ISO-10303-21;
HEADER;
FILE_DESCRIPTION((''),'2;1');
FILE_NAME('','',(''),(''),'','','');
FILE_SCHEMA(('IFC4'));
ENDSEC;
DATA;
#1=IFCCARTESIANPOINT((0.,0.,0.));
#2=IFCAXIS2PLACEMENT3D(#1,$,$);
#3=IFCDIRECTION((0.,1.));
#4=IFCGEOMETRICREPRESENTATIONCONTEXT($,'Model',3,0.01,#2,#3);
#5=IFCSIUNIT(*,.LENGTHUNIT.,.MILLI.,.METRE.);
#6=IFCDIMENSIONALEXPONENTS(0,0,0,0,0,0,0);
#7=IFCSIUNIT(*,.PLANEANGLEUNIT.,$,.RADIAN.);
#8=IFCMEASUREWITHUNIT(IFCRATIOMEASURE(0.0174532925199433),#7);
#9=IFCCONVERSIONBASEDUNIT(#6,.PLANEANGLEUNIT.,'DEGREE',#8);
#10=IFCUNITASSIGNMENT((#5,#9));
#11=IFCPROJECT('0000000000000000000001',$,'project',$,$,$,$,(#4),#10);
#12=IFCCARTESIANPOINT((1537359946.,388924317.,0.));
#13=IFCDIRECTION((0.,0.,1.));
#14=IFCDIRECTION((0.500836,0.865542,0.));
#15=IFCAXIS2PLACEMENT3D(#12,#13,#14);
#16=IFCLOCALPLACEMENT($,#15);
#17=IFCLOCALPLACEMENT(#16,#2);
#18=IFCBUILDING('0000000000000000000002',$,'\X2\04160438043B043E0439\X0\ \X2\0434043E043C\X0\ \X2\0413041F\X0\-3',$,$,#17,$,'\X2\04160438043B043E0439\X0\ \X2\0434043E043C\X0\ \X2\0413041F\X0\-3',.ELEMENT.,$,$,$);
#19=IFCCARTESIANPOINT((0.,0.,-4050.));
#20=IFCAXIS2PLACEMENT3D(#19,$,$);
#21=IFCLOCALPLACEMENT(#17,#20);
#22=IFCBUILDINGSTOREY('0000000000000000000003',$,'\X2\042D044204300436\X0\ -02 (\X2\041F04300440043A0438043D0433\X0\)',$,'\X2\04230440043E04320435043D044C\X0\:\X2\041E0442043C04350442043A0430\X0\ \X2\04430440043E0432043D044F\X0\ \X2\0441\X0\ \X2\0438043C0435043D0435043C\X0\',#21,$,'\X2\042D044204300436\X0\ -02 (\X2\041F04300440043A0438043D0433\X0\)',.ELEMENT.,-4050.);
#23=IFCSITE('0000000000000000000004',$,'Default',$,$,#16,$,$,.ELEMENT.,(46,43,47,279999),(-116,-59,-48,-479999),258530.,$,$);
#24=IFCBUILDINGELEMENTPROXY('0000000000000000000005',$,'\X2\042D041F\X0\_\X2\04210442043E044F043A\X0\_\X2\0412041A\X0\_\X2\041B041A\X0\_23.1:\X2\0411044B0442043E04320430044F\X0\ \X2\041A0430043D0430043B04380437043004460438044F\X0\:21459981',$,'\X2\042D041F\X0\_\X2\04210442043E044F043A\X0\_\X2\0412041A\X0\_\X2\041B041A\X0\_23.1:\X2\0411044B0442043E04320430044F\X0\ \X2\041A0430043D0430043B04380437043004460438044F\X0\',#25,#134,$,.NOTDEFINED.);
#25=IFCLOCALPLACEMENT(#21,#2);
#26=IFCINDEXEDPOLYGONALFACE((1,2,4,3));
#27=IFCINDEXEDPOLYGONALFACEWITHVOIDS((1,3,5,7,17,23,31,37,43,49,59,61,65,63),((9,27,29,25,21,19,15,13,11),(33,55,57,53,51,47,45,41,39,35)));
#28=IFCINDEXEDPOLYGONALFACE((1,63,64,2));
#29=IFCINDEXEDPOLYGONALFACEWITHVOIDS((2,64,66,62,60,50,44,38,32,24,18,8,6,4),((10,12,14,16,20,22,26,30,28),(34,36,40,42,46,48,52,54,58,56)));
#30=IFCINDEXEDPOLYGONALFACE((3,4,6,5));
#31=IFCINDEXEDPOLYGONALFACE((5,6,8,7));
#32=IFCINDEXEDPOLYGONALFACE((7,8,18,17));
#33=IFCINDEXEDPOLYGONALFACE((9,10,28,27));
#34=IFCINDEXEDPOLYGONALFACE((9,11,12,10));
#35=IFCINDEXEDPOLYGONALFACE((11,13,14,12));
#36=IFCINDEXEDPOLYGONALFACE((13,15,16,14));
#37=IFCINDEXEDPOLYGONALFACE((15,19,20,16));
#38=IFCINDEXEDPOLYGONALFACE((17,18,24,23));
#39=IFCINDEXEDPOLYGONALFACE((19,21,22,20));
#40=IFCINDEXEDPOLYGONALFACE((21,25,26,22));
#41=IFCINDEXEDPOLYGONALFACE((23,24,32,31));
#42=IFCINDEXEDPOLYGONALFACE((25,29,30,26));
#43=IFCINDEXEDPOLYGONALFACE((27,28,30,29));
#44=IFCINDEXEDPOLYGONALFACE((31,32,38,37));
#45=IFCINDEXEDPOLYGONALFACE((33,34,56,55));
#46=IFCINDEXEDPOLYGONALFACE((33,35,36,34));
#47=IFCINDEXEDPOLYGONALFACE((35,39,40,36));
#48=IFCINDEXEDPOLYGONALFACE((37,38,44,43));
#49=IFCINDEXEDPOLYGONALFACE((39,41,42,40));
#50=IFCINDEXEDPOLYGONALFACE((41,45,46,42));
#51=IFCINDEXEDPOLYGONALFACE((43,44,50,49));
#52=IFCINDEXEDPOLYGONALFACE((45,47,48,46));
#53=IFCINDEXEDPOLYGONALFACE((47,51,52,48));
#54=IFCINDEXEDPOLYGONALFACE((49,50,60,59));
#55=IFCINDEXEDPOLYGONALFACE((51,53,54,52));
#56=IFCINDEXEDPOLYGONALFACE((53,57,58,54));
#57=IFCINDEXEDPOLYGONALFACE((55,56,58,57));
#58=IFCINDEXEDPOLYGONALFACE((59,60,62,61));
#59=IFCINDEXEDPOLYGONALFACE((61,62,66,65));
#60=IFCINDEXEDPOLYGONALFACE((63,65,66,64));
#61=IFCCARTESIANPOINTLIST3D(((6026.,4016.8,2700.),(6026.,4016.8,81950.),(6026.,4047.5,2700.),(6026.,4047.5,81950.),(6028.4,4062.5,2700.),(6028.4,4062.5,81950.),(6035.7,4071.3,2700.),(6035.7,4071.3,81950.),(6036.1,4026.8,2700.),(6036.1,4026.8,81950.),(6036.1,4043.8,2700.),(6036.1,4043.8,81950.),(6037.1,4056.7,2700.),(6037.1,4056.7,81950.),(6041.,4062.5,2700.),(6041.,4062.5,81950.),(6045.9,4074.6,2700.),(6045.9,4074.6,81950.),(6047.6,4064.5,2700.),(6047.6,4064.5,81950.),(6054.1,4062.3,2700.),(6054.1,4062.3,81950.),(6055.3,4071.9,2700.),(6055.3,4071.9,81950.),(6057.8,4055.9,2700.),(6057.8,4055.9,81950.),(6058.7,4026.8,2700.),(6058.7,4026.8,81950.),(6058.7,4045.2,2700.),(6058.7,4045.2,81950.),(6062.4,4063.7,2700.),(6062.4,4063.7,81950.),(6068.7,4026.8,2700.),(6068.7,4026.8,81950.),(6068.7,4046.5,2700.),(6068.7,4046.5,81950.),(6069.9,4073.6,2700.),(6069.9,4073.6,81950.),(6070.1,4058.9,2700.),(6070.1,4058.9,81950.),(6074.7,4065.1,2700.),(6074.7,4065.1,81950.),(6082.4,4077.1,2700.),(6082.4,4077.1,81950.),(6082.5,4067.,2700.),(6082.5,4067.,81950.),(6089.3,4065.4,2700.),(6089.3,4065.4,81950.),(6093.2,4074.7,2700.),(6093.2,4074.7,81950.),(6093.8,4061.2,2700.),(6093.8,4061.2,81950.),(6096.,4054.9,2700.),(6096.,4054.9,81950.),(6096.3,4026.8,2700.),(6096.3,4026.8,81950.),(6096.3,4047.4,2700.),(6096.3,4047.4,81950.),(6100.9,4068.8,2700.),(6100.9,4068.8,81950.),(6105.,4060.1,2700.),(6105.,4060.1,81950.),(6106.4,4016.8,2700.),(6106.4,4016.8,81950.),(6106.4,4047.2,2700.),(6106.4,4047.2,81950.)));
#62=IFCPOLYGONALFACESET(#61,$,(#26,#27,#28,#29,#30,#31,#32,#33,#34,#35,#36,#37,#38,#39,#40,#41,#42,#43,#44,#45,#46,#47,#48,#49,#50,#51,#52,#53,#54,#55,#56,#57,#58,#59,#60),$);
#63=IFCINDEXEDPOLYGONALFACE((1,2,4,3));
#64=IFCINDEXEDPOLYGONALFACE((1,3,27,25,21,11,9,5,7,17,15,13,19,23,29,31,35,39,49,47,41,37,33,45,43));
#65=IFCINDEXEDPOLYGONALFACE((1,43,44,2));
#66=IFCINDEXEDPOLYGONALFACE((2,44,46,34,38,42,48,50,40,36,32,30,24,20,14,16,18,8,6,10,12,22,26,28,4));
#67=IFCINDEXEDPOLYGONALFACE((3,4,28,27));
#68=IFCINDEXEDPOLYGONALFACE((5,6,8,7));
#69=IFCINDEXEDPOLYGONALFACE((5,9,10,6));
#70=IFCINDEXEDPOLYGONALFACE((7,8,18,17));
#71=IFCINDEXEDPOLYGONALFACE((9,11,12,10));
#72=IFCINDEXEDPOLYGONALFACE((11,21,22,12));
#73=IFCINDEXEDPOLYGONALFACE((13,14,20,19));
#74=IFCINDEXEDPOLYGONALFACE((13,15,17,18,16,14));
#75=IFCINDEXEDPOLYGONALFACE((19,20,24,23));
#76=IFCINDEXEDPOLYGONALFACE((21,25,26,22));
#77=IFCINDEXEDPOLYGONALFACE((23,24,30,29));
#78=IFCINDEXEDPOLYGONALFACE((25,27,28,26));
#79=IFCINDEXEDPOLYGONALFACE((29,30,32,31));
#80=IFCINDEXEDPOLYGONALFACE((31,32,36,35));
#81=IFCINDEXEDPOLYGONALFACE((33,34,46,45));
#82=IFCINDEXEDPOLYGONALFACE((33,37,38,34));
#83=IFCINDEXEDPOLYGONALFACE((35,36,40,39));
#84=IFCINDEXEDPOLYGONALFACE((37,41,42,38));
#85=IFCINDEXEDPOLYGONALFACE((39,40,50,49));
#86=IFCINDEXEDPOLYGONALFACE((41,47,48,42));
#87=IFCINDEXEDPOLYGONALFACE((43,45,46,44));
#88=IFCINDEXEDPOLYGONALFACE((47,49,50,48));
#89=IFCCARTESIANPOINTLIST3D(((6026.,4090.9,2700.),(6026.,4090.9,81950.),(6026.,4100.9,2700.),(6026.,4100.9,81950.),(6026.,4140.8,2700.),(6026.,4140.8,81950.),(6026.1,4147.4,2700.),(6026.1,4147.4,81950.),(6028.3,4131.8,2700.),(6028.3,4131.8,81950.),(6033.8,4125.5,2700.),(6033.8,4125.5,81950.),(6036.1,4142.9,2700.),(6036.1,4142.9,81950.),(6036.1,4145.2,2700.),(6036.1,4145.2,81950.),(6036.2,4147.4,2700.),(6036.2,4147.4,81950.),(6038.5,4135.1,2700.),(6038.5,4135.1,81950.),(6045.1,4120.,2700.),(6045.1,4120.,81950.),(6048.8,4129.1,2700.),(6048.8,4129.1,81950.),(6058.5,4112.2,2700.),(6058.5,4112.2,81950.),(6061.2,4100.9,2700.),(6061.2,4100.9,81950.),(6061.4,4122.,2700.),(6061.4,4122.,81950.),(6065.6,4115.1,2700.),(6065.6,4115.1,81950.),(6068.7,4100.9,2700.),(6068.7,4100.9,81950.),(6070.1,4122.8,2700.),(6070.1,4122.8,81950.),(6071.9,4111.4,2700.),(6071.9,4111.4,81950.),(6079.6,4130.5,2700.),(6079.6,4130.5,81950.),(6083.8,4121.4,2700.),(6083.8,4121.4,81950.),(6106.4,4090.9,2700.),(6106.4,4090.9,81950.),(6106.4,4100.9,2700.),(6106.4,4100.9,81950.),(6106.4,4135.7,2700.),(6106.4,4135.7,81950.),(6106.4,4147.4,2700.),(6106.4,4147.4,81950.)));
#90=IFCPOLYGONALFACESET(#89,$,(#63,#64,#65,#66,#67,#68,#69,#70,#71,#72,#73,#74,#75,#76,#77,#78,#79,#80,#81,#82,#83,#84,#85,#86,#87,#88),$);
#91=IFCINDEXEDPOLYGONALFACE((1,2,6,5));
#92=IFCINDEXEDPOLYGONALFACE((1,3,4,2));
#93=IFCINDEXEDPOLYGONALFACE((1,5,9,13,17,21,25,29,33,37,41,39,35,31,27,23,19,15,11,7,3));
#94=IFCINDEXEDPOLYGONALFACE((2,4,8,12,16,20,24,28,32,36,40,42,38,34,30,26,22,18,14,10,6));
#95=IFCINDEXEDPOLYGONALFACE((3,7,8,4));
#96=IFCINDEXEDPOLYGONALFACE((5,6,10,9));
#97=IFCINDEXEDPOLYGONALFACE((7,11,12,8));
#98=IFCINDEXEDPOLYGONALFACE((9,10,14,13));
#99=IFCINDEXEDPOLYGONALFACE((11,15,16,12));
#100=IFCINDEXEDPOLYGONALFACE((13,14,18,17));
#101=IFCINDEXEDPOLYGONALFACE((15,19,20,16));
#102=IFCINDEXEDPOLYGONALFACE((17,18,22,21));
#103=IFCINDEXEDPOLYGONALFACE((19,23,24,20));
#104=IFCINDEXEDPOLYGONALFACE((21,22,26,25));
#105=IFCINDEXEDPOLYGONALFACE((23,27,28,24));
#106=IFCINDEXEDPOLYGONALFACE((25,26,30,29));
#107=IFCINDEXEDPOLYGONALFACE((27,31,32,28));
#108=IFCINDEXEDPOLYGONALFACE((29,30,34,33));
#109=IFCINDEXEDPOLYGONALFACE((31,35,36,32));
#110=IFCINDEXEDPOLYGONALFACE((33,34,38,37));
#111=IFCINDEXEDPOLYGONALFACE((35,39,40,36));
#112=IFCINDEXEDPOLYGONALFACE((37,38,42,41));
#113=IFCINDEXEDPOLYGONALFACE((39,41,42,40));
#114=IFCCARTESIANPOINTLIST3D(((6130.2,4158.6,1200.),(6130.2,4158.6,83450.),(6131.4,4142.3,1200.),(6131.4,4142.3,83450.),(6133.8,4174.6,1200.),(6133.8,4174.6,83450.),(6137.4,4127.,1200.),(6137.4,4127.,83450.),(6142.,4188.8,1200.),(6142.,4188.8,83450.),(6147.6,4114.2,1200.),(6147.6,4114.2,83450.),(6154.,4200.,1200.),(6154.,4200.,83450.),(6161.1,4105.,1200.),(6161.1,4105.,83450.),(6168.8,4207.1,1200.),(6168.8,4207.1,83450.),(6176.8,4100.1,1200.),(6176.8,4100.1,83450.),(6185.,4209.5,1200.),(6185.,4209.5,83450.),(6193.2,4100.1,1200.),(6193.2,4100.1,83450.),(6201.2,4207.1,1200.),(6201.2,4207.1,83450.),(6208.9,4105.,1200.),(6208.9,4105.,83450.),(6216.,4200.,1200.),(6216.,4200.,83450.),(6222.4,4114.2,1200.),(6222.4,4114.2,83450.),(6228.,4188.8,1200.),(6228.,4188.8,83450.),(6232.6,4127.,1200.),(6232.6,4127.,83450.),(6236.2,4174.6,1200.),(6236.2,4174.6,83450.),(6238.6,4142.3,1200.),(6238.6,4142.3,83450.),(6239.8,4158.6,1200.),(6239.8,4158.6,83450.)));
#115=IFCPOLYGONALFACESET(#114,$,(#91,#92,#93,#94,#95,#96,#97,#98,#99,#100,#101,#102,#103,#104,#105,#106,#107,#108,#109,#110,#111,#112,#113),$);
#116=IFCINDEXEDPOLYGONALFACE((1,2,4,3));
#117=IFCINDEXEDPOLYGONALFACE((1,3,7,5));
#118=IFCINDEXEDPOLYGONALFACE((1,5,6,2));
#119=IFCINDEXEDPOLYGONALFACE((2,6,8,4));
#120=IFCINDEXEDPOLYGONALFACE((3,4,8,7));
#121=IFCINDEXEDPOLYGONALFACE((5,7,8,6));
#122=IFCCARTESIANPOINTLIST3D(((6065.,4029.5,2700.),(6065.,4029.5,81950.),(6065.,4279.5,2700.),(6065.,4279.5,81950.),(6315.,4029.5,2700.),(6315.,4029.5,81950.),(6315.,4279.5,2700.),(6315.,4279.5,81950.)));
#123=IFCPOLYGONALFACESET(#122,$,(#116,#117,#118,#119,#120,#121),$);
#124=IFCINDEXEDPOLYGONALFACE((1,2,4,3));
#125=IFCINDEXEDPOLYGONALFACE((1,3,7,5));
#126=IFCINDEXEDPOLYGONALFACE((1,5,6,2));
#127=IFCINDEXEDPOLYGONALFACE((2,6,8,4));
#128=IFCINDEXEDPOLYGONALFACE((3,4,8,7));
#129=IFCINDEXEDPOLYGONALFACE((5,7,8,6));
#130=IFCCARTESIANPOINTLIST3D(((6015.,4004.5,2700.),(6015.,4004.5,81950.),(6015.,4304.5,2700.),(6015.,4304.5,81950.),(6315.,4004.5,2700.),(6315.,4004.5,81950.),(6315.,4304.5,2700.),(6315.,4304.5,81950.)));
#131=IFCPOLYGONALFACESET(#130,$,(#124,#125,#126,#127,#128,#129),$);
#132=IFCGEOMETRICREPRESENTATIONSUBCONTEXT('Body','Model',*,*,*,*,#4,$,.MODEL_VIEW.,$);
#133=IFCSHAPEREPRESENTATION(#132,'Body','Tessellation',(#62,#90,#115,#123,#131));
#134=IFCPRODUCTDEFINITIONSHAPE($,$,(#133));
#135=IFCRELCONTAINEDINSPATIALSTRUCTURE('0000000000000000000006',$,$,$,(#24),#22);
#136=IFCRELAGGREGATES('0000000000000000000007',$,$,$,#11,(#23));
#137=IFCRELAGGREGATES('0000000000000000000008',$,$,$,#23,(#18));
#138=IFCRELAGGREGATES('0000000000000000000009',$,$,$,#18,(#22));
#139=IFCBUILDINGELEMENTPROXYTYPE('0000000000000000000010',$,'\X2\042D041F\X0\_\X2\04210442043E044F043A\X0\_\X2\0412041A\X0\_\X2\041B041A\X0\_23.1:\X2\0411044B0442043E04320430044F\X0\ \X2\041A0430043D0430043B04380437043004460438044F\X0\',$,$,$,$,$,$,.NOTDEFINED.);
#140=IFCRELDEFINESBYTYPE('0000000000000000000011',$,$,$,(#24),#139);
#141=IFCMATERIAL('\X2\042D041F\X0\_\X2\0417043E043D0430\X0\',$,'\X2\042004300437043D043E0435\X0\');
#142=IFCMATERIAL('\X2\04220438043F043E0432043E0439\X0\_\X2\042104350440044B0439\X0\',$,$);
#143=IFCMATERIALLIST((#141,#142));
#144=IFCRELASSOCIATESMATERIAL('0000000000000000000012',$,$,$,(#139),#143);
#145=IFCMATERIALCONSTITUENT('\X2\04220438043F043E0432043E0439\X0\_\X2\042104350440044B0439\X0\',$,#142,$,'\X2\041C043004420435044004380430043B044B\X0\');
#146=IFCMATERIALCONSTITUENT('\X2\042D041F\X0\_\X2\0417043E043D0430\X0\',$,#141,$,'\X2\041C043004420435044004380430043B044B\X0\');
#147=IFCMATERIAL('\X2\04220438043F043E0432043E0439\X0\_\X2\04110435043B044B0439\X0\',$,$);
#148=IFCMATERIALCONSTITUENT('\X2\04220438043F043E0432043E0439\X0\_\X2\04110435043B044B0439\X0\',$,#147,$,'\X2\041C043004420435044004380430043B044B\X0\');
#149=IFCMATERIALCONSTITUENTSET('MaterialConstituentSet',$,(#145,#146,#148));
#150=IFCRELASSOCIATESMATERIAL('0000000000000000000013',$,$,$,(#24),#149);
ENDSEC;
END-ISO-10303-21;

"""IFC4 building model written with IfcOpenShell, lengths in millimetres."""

from ifc_helpers import new_model, entity, si_unit, converted_unit, direction, frame, frame_2d, origin, place, context, subcontext, project, spatial, polyline, rectangle, circle, outline, extrude, source, transform, mapped, material, material_list, constituent, constituent_set, type_object, type_shapes, element, save


model = new_model("IFC4")

# Units and contexts
model_context = context("Model", 3, precision=0.01, world=origin(), true_north=direction((0.0, 1.0)))
body_context = subcontext(model_context, "Body", "Model", "MODEL_VIEW")
ifc_project = project(units=[si_unit("LENGTHUNIT", "METRE", prefix="MILLI"), converted_unit("PLANEANGLEUNIT", "DEGREE", entity("IfcRatioMeasure", 0.0174532925199433), si_unit("PLANEANGLEUNIT", "RADIAN"), dimensions=[0, 0, 0, 0, 0, 0, 0])], contexts=[model_context])

# Site, building, storey
site_placement = place(None, frame((1537359946.0, 388924317.0, 0.0), z_axis=(0.0, 0.0, 1.0), x_axis=(0.500836, 0.865542, 0.0)))
site = spatial("IfcSite", under=ifc_project, at=site_placement, Name="Default", CompositionType="ELEMENT", RefLatitude=(46, 43, 47, 279999), RefLongitude=(-116, -59, -48, -479999), RefElevation=258530.0)
building_placement = place(site_placement, origin())
building = spatial("IfcBuilding", under=site, at=building_placement, Name="Жилой дом ГП-3", LongName="Жилой дом ГП-3", CompositionType="ELEMENT")
storey_placement = place(building_placement, frame((0.0, 0.0, -4050.0)))
storey = spatial("IfcBuildingStorey", under=building, at=storey_placement, Name="Этаж -02 (Паркинг)", ObjectType="Уровень:Отметка уровня с именем", LongName="Этаж -02 (Паркинг)", CompositionType="ELEMENT", Elevation=-4050.0)

# Building element proxy
ifc_material_1 = material(Name="Типовой_Серый")
ifc_material_2 = material(Name="ЭП_Зона", Category="Разное")
ifc_material_3 = material(Name="Типовой_Белый")
ifc_material_list_1 = material_list([ifc_material_2, ifc_material_1])
building_element_proxy_type_1 = type_object("IfcBuildingElementProxyType", Name="ЭП_Стояк_ВК_ЛК_23.1:Бытовая Канализация", PredefinedType="NOTDEFINED", material=ifc_material_list_1)
shared_shape_1 = source(origin(), body_context, "Body", "SweptSolid", [
    extrude(outline(polyline([(-42.2, -39.0), (-11.8, -39.0), (1.1, -37.6), (9.8, -33.5), (15.7, -25.8), (18.0, -15.0), (14.6, -2.5), (4.7, 5.0), (12.8, 12.1), (15.5, 21.5), (12.3, 31.8), (3.4, 39.0), (-11.6, 41.4), (-42.2, 41.4), (-42.2, -39.0)]), holes=[polyline([(-32.2, 8.8), (-32.2, 31.4), (-15.2, 31.4), (-2.3, 30.3), (3.5, 26.4), (5.5, 19.9), (3.3, 13.3), (-3.1, 9.6), (-13.9, 8.8), (-32.2, 8.8)]), polyline([(-32.2, -28.9), (-32.2, -1.3), (-12.6, -1.3), (-0.2, -2.6), (6.1, -7.3), (8.0, -15.1), (6.3, -21.9), (2.2, -26.3), (-4.1, -28.5), (-11.6, -28.9), (-32.2, -28.9)])]), frame((54.5, -52.4, -1350.0)), (0.0, 0.0, 1.0), 79250.0),
    extrude(outline(polyline([(-32.1, -31.9), (48.3, -31.9), (48.3, -21.8), (10.6, -21.8), (13.8, -11.4), (25.6, -1.3), (48.3, 13.0), (48.3, 24.6), (21.4, 7.7), (12.0, 0.1), (7.4, -7.7), (3.3, -0.7), (-9.3, 6.4), (-19.7, 12.3), (-22.1, 20.2), (-22.0, 22.4), (-22.0, 24.6), (-32.0, 24.6), (-32.1, 18.0), (-29.9, 9.0), (-24.3, 2.8), (-13.1, -2.8), (0.4, -10.6), (3.0, -21.8), (-32.1, -21.8), (-32.1, -31.9)])), frame((118.2, -43.1, -1350.0), z_axis=(0.0, 0.0, 1.0), x_axis=(0.0, -1.0, 0.0)), (0.0, 0.0, 1.0), 79250.0),
    extrude(circle(Radius=55.0, at=frame_2d((0.0, 0.0), x_axis=(1.0, 0.0))), frame((150.0, -170.0, -2850.0)), (0.0, 0.0, 1.0), 82250.0),
    extrude(rectangle(XDim=250.0, YDim=250.0, at=frame_2d((0.0, 0.0), x_axis=(1.0, 0.0))), frame((150.0, -175.0, -1350.0)), (0.0, 0.0, 1.0), 79250.0),
    extrude(rectangle(XDim=300.0, YDim=300.0, at=frame_2d((0.0, 0.0), x_axis=(1.0, 0.0))), frame((150.0, -150.0, -1350.0)), (0.0, 0.0, 1.0), 79250.0),
])
type_shapes(building_element_proxy_type_1, [shared_shape_1])
ifc_constituent_1 = constituent(ifc_material_1, Name="Типовой_Серый", Category="Материалы")
ifc_constituent_2 = constituent(ifc_material_2, Name="ЭП_Зона", Category="Материалы")
ifc_constituent_3 = constituent(ifc_material_3, Name="Типовой_Белый", Category="Материалы")
ifc_constituent_set_1 = constituent_set(constituents=[ifc_constituent_1, ifc_constituent_2, ifc_constituent_3], Name="MaterialConstituentSet")
proxy_1_placement = place(storey_placement, frame((6015.0, 4004.5, 4050.0), z_axis=(0.0, 0.0, 1.0), x_axis=(0.0, 1.0, 0.0)))
element("IfcBuildingElementProxy", 1, at=proxy_1_placement, inside=storey, type_object=building_element_proxy_type_1, material=ifc_constituent_set_1, Name="ЭП_Стояк_ВК_ЛК_23.1:Бытовая Канализация:21459981", ObjectType="ЭП_Стояк_ВК_ЛК_23.1:Бытовая Канализация", PredefinedType="NOTDEFINED", context=body_context, shape_type="MappedRepresentation", body=[
    mapped(shared_shape_1, transform((0.0, 0.0, 0.0), scale=1.0)),
])

save(model, "model.ifc")
